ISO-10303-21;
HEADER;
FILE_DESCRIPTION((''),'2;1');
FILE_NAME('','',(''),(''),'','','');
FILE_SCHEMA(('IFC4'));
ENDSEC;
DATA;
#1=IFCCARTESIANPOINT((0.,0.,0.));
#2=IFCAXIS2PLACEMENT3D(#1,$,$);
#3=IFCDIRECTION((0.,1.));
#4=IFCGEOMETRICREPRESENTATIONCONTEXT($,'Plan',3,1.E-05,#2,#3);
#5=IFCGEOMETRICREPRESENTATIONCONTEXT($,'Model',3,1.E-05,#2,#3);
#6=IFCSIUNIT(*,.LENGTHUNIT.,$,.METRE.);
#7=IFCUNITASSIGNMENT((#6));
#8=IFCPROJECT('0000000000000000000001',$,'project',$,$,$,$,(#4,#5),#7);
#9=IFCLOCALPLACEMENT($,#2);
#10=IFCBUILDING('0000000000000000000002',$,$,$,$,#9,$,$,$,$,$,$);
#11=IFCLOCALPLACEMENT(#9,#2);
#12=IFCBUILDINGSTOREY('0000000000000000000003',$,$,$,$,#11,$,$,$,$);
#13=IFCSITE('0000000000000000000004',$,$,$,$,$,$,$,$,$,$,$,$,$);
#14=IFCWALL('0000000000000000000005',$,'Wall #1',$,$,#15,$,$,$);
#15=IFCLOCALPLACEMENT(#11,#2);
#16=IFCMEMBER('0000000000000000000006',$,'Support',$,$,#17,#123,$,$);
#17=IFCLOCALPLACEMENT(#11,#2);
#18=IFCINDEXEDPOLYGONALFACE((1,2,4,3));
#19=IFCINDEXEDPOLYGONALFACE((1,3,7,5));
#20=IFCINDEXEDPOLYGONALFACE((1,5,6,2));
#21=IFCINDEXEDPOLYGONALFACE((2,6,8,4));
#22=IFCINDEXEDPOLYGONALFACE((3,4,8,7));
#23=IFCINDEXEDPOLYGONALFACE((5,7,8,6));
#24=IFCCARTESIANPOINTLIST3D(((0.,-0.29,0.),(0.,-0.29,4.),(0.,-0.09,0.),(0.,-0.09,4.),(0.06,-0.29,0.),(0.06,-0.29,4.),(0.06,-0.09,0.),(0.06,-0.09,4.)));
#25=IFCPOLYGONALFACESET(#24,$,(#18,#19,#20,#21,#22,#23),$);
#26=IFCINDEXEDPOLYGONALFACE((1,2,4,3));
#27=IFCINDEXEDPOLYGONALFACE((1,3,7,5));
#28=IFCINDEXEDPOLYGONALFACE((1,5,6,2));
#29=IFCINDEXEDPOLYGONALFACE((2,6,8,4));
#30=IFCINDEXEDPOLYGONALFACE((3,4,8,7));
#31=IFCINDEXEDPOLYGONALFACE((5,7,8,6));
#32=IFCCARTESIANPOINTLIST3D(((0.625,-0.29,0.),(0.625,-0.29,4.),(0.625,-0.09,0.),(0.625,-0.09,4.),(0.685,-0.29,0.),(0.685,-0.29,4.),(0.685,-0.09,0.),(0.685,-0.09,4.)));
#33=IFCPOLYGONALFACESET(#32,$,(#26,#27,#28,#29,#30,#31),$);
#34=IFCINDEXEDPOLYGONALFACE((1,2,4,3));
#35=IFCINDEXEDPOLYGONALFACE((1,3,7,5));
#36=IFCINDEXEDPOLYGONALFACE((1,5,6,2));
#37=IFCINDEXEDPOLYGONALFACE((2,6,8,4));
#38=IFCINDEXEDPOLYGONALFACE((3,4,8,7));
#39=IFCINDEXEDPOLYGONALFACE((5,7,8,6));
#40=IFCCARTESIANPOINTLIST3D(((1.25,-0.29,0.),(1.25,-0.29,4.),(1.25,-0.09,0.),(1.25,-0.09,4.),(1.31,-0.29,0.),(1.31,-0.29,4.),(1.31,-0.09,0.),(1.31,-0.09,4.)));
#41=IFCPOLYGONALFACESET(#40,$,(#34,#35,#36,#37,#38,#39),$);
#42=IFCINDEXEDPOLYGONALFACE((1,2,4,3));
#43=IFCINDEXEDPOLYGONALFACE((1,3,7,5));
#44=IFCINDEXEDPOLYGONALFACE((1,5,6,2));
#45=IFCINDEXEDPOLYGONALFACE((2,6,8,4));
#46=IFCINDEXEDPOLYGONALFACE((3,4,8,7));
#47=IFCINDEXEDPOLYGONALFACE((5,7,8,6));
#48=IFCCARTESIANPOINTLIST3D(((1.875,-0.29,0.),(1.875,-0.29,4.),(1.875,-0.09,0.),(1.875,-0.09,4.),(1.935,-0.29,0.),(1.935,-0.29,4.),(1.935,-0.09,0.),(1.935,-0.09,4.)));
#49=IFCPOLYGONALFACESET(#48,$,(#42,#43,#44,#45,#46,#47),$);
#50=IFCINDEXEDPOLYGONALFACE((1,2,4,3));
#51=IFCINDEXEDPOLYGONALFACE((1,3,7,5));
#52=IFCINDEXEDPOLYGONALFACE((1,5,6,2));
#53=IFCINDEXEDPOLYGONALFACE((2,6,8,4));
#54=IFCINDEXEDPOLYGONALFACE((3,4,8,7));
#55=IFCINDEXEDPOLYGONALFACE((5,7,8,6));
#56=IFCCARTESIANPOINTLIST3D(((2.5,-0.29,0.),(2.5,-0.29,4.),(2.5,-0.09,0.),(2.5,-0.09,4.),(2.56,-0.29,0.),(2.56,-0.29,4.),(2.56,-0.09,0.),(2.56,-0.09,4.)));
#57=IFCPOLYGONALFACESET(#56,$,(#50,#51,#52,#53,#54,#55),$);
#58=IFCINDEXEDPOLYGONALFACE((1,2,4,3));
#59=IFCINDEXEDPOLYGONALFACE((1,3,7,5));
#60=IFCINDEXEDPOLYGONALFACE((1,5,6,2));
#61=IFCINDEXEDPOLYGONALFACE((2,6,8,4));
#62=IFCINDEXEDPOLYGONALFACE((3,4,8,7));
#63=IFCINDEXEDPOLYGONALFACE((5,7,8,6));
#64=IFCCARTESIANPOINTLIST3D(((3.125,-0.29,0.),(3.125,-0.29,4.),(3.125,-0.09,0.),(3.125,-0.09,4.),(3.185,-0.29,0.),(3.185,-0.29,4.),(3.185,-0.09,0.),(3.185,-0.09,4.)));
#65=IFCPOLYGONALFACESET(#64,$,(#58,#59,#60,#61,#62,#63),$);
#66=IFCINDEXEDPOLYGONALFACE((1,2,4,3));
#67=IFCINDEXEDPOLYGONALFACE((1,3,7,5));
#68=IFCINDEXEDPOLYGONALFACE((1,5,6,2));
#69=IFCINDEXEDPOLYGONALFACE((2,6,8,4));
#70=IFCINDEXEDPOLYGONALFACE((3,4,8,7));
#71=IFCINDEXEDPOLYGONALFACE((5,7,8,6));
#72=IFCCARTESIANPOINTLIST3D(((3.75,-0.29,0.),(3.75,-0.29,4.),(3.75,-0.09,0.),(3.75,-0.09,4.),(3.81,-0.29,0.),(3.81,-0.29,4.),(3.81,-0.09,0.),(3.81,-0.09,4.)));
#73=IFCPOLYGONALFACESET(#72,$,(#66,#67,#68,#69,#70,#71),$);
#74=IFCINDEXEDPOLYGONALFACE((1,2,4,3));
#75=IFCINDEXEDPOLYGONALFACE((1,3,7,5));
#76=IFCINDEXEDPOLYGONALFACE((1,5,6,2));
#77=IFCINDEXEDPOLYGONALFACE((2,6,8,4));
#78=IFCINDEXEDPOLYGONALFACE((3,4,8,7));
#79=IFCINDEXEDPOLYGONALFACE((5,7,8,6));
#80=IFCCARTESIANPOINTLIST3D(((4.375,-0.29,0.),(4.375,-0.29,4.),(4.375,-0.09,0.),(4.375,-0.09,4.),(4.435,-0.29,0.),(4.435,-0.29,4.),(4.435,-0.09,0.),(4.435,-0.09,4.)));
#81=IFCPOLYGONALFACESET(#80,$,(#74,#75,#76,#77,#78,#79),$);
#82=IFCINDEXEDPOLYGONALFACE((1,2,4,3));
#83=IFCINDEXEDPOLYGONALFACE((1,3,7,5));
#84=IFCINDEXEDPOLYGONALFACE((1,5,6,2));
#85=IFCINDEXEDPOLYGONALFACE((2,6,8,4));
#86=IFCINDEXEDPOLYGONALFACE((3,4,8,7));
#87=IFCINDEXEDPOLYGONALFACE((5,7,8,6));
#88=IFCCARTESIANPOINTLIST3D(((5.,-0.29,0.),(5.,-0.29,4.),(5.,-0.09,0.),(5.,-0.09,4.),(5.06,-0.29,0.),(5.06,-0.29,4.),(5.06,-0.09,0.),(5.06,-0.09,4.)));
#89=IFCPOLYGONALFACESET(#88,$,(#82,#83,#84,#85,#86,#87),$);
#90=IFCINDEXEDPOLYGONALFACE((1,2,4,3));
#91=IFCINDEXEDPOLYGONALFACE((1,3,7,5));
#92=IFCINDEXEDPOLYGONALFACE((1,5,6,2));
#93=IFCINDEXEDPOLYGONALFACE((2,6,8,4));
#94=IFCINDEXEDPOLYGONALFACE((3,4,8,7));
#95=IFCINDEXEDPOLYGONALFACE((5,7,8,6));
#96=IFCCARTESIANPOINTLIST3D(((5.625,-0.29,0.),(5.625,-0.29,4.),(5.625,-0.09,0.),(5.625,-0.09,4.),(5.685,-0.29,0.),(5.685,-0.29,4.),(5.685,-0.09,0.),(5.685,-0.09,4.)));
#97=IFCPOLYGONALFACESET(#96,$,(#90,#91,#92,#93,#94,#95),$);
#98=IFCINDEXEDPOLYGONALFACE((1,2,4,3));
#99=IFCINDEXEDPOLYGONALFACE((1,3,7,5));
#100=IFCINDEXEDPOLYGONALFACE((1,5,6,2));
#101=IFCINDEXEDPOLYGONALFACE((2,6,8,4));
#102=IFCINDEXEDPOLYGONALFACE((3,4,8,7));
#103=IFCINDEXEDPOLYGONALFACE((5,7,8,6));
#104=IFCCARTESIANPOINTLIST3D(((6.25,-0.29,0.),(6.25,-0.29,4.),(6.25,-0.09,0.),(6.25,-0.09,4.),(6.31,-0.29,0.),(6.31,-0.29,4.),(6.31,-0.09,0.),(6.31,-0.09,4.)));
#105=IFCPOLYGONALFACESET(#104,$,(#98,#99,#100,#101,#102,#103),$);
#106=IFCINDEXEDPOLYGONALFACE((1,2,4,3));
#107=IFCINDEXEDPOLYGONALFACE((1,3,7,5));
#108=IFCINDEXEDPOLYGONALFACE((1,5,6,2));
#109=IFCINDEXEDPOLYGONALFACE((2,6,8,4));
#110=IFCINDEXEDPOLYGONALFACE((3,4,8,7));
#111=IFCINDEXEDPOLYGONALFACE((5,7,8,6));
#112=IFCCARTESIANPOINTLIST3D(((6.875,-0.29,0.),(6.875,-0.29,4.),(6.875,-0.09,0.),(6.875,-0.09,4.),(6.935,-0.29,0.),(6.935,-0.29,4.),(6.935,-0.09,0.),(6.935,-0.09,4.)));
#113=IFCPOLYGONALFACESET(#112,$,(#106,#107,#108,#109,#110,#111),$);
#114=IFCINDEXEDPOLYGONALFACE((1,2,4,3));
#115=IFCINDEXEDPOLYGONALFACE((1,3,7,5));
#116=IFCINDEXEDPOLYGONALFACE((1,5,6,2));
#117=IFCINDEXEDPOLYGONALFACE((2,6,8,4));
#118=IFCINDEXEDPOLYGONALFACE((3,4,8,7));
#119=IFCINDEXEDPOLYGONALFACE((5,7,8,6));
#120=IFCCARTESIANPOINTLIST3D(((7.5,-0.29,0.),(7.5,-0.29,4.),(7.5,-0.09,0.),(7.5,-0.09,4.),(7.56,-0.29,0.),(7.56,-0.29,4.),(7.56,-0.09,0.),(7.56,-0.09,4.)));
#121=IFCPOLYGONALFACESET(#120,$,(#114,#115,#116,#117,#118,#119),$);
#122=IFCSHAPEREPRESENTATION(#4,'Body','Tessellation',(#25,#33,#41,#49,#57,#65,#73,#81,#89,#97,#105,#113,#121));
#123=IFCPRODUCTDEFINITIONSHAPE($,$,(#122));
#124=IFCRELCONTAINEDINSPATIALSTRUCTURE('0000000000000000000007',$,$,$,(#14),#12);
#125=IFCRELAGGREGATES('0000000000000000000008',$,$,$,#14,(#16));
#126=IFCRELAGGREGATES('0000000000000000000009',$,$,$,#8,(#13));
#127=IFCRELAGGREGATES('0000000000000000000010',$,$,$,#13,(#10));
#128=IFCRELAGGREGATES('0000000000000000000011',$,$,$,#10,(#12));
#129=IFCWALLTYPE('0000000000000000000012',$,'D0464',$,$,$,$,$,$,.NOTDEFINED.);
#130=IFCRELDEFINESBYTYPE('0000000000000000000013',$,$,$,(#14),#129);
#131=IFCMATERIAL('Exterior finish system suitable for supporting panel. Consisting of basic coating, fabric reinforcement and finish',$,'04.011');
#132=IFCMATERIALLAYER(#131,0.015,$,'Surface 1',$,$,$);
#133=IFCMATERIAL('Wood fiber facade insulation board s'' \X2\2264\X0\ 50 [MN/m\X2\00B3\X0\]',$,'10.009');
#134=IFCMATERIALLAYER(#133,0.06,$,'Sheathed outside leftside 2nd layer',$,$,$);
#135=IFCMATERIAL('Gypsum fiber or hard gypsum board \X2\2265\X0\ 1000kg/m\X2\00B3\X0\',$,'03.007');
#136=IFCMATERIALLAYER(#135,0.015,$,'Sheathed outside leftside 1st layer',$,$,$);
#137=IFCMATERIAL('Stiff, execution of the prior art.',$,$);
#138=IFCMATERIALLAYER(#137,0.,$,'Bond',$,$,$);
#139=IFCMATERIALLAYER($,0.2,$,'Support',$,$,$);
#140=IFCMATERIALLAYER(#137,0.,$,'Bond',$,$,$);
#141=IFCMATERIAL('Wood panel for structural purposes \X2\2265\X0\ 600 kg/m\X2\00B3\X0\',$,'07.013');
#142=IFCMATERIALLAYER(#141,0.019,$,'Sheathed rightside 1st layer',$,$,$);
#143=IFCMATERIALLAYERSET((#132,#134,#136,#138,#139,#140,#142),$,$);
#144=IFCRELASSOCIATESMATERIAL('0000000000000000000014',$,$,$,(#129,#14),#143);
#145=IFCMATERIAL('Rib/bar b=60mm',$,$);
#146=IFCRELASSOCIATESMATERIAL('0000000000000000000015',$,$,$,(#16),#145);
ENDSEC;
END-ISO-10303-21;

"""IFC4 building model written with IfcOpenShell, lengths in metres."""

from ifc_helpers import new_model, si_unit, direction, frame, frame_2d, origin, place, context, project, spatial, rectangle, extrude, material, layer, layer_set, type_object, element, aggregate, save


model = new_model("IFC4")

# Units and contexts
plan_context = context("Plan", 3, precision=1e-05, world=origin(), true_north=direction((0.0, 1.0)))
model_context = context("Model", 3, precision=1e-05, world=origin(), true_north=direction((0.0, 1.0)))
ifc_project = project(units=[si_unit("LENGTHUNIT", "METRE")], contexts=[plan_context, model_context])

# Site, building, storey
site = spatial("IfcSite", under=ifc_project)
building_placement = place(None, origin())
building = spatial("IfcBuilding", under=site, at=building_placement)
storey_placement = place(building_placement, origin())
storey = spatial("IfcBuildingStorey", under=building, at=storey_placement)

# Wall, member
ifc_material_1 = material(Name="Exterior finish system suitable for supporting panel. Consisting of basic coating, fabric reinforcement and finish", Category="04.011")
ifc_layer_1 = layer(ifc_material_1, 0.015, Name="Surface 1")
ifc_material_2 = material(Name="Wood fiber facade insulation board s' ≤ 50 [MN/m³]", Category="10.009")
ifc_layer_2 = layer(ifc_material_2, 0.06, Name="Sheathed outside leftside 2nd layer")
ifc_material_3 = material(Name="Gypsum fiber or hard gypsum board ≥ 1000kg/m³", Category="03.007")
ifc_layer_3 = layer(ifc_material_3, 0.015, Name="Sheathed outside leftside 1st layer")
ifc_material_4 = material(Name="Stiff, execution of the prior art.")
ifc_layer_4 = layer(ifc_material_4, 0.0, Name="Bond")
ifc_layer_5 = layer(None, 0.2, Name="Support")
ifc_layer_6 = layer(ifc_material_4, 0.0, Name="Bond")
ifc_material_5 = material(Name="Wood panel for structural purposes ≥ 600 kg/m³", Category="07.013")
ifc_layer_7 = layer(ifc_material_5, 0.019, Name="Sheathed rightside 1st layer")
ifc_layer_set = layer_set([ifc_layer_1, ifc_layer_2, ifc_layer_3, ifc_layer_4, ifc_layer_5, ifc_layer_6, ifc_layer_7])
wall_type = type_object("IfcWallType", Name="D0464", PredefinedType="NOTDEFINED", material=ifc_layer_set)
wall_placement = place(None, frame((0.0, 0.0, 0.0), z_axis=(0.0, -1.0, 0.0), x_axis=(1.0, 0.0, 0.0)))
wall = element("IfcWall", 1, at=wall_placement, inside=storey, type_object=wall_type, material=ifc_layer_set, Name="Wall #1")
ifc_material_6 = material(Name="Rib/bar b=60mm")
member_1_placement = place(wall_placement, origin())
member_1 = element("IfcMember", 2, at=member_1_placement, material=ifc_material_6, Name="Support", context=plan_context, shape_type="SweptSolid", body=[
    extrude(rectangle(XDim=0.06, YDim=0.2, at=frame_2d((0.03, 0.1), x_axis=(1.0, 0.0))), frame((0.0, 4.0, 0.09), z_axis=(0.0, -1.0, 0.0), x_axis=(1.0, 0.0, 0.0)), (0.0, 0.0, 1.0), 4.0),
    extrude(rectangle(XDim=0.06, YDim=0.2, at=frame_2d((0.03, 0.1), x_axis=(1.0, 0.0))), frame((0.625, 4.0, 0.09), z_axis=(0.0, -1.0, 0.0), x_axis=(1.0, 0.0, 0.0)), (0.0, 0.0, 1.0), 4.0),
    extrude(rectangle(XDim=0.06, YDim=0.2, at=frame_2d((0.03, 0.1), x_axis=(1.0, 0.0))), frame((1.25, 4.0, 0.09), z_axis=(0.0, -1.0, 0.0), x_axis=(1.0, 0.0, 0.0)), (0.0, 0.0, 1.0), 4.0),
    extrude(rectangle(XDim=0.06, YDim=0.2, at=frame_2d((0.03, 0.1), x_axis=(1.0, 0.0))), frame((1.875, 4.0, 0.09), z_axis=(0.0, -1.0, 0.0), x_axis=(1.0, 0.0, 0.0)), (0.0, 0.0, 1.0), 4.0),
    extrude(rectangle(XDim=0.06, YDim=0.2, at=frame_2d((0.03, 0.1), x_axis=(1.0, 0.0))), frame((2.5, 4.0, 0.09), z_axis=(0.0, -1.0, 0.0), x_axis=(1.0, 0.0, 0.0)), (0.0, 0.0, 1.0), 4.0),
    extrude(rectangle(XDim=0.06, YDim=0.2, at=frame_2d((0.03, 0.1), x_axis=(1.0, 0.0))), frame((3.125, 4.0, 0.09), z_axis=(0.0, -1.0, 0.0), x_axis=(1.0, 0.0, 0.0)), (0.0, 0.0, 1.0), 4.0),
    extrude(rectangle(XDim=0.06, YDim=0.2, at=frame_2d((0.03, 0.1), x_axis=(1.0, 0.0))), frame((3.75, 4.0, 0.09), z_axis=(0.0, -1.0, 0.0), x_axis=(1.0, 0.0, 0.0)), (0.0, 0.0, 1.0), 4.0),
    extrude(rectangle(XDim=0.06, YDim=0.2, at=frame_2d((0.03, 0.1), x_axis=(1.0, 0.0))), frame((4.375, 4.0, 0.09), z_axis=(0.0, -1.0, 0.0), x_axis=(1.0, 0.0, 0.0)), (0.0, 0.0, 1.0), 4.0),
    extrude(rectangle(XDim=0.06, YDim=0.2, at=frame_2d((0.03, 0.1), x_axis=(1.0, 0.0))), frame((5.0, 4.0, 0.09), z_axis=(0.0, -1.0, 0.0), x_axis=(1.0, 0.0, 0.0)), (0.0, 0.0, 1.0), 4.0),
    extrude(rectangle(XDim=0.06, YDim=0.2, at=frame_2d((0.03, 0.1), x_axis=(1.0, 0.0))), frame((5.625, 4.0, 0.09), z_axis=(0.0, -1.0, 0.0), x_axis=(1.0, 0.0, 0.0)), (0.0, 0.0, 1.0), 4.0),
    extrude(rectangle(XDim=0.06, YDim=0.2, at=frame_2d((0.03, 0.1), x_axis=(1.0, 0.0))), frame((6.25, 4.0, 0.09), z_axis=(0.0, -1.0, 0.0), x_axis=(1.0, 0.0, 0.0)), (0.0, 0.0, 1.0), 4.0),
    extrude(rectangle(XDim=0.06, YDim=0.2, at=frame_2d((0.03, 0.1), x_axis=(1.0, 0.0))), frame((6.875, 4.0, 0.09), z_axis=(0.0, -1.0, 0.0), x_axis=(1.0, 0.0, 0.0)), (0.0, 0.0, 1.0), 4.0),
    extrude(rectangle(XDim=0.06, YDim=0.2, at=frame_2d((0.03, 0.1), x_axis=(1.0, 0.0))), frame((7.5, 4.0, 0.09), z_axis=(0.0, -1.0, 0.0), x_axis=(1.0, 0.0, 0.0)), (0.0, 0.0, 1.0), 4.0),
])
aggregate(wall, [member_1])

save(model, "model.ifc")
